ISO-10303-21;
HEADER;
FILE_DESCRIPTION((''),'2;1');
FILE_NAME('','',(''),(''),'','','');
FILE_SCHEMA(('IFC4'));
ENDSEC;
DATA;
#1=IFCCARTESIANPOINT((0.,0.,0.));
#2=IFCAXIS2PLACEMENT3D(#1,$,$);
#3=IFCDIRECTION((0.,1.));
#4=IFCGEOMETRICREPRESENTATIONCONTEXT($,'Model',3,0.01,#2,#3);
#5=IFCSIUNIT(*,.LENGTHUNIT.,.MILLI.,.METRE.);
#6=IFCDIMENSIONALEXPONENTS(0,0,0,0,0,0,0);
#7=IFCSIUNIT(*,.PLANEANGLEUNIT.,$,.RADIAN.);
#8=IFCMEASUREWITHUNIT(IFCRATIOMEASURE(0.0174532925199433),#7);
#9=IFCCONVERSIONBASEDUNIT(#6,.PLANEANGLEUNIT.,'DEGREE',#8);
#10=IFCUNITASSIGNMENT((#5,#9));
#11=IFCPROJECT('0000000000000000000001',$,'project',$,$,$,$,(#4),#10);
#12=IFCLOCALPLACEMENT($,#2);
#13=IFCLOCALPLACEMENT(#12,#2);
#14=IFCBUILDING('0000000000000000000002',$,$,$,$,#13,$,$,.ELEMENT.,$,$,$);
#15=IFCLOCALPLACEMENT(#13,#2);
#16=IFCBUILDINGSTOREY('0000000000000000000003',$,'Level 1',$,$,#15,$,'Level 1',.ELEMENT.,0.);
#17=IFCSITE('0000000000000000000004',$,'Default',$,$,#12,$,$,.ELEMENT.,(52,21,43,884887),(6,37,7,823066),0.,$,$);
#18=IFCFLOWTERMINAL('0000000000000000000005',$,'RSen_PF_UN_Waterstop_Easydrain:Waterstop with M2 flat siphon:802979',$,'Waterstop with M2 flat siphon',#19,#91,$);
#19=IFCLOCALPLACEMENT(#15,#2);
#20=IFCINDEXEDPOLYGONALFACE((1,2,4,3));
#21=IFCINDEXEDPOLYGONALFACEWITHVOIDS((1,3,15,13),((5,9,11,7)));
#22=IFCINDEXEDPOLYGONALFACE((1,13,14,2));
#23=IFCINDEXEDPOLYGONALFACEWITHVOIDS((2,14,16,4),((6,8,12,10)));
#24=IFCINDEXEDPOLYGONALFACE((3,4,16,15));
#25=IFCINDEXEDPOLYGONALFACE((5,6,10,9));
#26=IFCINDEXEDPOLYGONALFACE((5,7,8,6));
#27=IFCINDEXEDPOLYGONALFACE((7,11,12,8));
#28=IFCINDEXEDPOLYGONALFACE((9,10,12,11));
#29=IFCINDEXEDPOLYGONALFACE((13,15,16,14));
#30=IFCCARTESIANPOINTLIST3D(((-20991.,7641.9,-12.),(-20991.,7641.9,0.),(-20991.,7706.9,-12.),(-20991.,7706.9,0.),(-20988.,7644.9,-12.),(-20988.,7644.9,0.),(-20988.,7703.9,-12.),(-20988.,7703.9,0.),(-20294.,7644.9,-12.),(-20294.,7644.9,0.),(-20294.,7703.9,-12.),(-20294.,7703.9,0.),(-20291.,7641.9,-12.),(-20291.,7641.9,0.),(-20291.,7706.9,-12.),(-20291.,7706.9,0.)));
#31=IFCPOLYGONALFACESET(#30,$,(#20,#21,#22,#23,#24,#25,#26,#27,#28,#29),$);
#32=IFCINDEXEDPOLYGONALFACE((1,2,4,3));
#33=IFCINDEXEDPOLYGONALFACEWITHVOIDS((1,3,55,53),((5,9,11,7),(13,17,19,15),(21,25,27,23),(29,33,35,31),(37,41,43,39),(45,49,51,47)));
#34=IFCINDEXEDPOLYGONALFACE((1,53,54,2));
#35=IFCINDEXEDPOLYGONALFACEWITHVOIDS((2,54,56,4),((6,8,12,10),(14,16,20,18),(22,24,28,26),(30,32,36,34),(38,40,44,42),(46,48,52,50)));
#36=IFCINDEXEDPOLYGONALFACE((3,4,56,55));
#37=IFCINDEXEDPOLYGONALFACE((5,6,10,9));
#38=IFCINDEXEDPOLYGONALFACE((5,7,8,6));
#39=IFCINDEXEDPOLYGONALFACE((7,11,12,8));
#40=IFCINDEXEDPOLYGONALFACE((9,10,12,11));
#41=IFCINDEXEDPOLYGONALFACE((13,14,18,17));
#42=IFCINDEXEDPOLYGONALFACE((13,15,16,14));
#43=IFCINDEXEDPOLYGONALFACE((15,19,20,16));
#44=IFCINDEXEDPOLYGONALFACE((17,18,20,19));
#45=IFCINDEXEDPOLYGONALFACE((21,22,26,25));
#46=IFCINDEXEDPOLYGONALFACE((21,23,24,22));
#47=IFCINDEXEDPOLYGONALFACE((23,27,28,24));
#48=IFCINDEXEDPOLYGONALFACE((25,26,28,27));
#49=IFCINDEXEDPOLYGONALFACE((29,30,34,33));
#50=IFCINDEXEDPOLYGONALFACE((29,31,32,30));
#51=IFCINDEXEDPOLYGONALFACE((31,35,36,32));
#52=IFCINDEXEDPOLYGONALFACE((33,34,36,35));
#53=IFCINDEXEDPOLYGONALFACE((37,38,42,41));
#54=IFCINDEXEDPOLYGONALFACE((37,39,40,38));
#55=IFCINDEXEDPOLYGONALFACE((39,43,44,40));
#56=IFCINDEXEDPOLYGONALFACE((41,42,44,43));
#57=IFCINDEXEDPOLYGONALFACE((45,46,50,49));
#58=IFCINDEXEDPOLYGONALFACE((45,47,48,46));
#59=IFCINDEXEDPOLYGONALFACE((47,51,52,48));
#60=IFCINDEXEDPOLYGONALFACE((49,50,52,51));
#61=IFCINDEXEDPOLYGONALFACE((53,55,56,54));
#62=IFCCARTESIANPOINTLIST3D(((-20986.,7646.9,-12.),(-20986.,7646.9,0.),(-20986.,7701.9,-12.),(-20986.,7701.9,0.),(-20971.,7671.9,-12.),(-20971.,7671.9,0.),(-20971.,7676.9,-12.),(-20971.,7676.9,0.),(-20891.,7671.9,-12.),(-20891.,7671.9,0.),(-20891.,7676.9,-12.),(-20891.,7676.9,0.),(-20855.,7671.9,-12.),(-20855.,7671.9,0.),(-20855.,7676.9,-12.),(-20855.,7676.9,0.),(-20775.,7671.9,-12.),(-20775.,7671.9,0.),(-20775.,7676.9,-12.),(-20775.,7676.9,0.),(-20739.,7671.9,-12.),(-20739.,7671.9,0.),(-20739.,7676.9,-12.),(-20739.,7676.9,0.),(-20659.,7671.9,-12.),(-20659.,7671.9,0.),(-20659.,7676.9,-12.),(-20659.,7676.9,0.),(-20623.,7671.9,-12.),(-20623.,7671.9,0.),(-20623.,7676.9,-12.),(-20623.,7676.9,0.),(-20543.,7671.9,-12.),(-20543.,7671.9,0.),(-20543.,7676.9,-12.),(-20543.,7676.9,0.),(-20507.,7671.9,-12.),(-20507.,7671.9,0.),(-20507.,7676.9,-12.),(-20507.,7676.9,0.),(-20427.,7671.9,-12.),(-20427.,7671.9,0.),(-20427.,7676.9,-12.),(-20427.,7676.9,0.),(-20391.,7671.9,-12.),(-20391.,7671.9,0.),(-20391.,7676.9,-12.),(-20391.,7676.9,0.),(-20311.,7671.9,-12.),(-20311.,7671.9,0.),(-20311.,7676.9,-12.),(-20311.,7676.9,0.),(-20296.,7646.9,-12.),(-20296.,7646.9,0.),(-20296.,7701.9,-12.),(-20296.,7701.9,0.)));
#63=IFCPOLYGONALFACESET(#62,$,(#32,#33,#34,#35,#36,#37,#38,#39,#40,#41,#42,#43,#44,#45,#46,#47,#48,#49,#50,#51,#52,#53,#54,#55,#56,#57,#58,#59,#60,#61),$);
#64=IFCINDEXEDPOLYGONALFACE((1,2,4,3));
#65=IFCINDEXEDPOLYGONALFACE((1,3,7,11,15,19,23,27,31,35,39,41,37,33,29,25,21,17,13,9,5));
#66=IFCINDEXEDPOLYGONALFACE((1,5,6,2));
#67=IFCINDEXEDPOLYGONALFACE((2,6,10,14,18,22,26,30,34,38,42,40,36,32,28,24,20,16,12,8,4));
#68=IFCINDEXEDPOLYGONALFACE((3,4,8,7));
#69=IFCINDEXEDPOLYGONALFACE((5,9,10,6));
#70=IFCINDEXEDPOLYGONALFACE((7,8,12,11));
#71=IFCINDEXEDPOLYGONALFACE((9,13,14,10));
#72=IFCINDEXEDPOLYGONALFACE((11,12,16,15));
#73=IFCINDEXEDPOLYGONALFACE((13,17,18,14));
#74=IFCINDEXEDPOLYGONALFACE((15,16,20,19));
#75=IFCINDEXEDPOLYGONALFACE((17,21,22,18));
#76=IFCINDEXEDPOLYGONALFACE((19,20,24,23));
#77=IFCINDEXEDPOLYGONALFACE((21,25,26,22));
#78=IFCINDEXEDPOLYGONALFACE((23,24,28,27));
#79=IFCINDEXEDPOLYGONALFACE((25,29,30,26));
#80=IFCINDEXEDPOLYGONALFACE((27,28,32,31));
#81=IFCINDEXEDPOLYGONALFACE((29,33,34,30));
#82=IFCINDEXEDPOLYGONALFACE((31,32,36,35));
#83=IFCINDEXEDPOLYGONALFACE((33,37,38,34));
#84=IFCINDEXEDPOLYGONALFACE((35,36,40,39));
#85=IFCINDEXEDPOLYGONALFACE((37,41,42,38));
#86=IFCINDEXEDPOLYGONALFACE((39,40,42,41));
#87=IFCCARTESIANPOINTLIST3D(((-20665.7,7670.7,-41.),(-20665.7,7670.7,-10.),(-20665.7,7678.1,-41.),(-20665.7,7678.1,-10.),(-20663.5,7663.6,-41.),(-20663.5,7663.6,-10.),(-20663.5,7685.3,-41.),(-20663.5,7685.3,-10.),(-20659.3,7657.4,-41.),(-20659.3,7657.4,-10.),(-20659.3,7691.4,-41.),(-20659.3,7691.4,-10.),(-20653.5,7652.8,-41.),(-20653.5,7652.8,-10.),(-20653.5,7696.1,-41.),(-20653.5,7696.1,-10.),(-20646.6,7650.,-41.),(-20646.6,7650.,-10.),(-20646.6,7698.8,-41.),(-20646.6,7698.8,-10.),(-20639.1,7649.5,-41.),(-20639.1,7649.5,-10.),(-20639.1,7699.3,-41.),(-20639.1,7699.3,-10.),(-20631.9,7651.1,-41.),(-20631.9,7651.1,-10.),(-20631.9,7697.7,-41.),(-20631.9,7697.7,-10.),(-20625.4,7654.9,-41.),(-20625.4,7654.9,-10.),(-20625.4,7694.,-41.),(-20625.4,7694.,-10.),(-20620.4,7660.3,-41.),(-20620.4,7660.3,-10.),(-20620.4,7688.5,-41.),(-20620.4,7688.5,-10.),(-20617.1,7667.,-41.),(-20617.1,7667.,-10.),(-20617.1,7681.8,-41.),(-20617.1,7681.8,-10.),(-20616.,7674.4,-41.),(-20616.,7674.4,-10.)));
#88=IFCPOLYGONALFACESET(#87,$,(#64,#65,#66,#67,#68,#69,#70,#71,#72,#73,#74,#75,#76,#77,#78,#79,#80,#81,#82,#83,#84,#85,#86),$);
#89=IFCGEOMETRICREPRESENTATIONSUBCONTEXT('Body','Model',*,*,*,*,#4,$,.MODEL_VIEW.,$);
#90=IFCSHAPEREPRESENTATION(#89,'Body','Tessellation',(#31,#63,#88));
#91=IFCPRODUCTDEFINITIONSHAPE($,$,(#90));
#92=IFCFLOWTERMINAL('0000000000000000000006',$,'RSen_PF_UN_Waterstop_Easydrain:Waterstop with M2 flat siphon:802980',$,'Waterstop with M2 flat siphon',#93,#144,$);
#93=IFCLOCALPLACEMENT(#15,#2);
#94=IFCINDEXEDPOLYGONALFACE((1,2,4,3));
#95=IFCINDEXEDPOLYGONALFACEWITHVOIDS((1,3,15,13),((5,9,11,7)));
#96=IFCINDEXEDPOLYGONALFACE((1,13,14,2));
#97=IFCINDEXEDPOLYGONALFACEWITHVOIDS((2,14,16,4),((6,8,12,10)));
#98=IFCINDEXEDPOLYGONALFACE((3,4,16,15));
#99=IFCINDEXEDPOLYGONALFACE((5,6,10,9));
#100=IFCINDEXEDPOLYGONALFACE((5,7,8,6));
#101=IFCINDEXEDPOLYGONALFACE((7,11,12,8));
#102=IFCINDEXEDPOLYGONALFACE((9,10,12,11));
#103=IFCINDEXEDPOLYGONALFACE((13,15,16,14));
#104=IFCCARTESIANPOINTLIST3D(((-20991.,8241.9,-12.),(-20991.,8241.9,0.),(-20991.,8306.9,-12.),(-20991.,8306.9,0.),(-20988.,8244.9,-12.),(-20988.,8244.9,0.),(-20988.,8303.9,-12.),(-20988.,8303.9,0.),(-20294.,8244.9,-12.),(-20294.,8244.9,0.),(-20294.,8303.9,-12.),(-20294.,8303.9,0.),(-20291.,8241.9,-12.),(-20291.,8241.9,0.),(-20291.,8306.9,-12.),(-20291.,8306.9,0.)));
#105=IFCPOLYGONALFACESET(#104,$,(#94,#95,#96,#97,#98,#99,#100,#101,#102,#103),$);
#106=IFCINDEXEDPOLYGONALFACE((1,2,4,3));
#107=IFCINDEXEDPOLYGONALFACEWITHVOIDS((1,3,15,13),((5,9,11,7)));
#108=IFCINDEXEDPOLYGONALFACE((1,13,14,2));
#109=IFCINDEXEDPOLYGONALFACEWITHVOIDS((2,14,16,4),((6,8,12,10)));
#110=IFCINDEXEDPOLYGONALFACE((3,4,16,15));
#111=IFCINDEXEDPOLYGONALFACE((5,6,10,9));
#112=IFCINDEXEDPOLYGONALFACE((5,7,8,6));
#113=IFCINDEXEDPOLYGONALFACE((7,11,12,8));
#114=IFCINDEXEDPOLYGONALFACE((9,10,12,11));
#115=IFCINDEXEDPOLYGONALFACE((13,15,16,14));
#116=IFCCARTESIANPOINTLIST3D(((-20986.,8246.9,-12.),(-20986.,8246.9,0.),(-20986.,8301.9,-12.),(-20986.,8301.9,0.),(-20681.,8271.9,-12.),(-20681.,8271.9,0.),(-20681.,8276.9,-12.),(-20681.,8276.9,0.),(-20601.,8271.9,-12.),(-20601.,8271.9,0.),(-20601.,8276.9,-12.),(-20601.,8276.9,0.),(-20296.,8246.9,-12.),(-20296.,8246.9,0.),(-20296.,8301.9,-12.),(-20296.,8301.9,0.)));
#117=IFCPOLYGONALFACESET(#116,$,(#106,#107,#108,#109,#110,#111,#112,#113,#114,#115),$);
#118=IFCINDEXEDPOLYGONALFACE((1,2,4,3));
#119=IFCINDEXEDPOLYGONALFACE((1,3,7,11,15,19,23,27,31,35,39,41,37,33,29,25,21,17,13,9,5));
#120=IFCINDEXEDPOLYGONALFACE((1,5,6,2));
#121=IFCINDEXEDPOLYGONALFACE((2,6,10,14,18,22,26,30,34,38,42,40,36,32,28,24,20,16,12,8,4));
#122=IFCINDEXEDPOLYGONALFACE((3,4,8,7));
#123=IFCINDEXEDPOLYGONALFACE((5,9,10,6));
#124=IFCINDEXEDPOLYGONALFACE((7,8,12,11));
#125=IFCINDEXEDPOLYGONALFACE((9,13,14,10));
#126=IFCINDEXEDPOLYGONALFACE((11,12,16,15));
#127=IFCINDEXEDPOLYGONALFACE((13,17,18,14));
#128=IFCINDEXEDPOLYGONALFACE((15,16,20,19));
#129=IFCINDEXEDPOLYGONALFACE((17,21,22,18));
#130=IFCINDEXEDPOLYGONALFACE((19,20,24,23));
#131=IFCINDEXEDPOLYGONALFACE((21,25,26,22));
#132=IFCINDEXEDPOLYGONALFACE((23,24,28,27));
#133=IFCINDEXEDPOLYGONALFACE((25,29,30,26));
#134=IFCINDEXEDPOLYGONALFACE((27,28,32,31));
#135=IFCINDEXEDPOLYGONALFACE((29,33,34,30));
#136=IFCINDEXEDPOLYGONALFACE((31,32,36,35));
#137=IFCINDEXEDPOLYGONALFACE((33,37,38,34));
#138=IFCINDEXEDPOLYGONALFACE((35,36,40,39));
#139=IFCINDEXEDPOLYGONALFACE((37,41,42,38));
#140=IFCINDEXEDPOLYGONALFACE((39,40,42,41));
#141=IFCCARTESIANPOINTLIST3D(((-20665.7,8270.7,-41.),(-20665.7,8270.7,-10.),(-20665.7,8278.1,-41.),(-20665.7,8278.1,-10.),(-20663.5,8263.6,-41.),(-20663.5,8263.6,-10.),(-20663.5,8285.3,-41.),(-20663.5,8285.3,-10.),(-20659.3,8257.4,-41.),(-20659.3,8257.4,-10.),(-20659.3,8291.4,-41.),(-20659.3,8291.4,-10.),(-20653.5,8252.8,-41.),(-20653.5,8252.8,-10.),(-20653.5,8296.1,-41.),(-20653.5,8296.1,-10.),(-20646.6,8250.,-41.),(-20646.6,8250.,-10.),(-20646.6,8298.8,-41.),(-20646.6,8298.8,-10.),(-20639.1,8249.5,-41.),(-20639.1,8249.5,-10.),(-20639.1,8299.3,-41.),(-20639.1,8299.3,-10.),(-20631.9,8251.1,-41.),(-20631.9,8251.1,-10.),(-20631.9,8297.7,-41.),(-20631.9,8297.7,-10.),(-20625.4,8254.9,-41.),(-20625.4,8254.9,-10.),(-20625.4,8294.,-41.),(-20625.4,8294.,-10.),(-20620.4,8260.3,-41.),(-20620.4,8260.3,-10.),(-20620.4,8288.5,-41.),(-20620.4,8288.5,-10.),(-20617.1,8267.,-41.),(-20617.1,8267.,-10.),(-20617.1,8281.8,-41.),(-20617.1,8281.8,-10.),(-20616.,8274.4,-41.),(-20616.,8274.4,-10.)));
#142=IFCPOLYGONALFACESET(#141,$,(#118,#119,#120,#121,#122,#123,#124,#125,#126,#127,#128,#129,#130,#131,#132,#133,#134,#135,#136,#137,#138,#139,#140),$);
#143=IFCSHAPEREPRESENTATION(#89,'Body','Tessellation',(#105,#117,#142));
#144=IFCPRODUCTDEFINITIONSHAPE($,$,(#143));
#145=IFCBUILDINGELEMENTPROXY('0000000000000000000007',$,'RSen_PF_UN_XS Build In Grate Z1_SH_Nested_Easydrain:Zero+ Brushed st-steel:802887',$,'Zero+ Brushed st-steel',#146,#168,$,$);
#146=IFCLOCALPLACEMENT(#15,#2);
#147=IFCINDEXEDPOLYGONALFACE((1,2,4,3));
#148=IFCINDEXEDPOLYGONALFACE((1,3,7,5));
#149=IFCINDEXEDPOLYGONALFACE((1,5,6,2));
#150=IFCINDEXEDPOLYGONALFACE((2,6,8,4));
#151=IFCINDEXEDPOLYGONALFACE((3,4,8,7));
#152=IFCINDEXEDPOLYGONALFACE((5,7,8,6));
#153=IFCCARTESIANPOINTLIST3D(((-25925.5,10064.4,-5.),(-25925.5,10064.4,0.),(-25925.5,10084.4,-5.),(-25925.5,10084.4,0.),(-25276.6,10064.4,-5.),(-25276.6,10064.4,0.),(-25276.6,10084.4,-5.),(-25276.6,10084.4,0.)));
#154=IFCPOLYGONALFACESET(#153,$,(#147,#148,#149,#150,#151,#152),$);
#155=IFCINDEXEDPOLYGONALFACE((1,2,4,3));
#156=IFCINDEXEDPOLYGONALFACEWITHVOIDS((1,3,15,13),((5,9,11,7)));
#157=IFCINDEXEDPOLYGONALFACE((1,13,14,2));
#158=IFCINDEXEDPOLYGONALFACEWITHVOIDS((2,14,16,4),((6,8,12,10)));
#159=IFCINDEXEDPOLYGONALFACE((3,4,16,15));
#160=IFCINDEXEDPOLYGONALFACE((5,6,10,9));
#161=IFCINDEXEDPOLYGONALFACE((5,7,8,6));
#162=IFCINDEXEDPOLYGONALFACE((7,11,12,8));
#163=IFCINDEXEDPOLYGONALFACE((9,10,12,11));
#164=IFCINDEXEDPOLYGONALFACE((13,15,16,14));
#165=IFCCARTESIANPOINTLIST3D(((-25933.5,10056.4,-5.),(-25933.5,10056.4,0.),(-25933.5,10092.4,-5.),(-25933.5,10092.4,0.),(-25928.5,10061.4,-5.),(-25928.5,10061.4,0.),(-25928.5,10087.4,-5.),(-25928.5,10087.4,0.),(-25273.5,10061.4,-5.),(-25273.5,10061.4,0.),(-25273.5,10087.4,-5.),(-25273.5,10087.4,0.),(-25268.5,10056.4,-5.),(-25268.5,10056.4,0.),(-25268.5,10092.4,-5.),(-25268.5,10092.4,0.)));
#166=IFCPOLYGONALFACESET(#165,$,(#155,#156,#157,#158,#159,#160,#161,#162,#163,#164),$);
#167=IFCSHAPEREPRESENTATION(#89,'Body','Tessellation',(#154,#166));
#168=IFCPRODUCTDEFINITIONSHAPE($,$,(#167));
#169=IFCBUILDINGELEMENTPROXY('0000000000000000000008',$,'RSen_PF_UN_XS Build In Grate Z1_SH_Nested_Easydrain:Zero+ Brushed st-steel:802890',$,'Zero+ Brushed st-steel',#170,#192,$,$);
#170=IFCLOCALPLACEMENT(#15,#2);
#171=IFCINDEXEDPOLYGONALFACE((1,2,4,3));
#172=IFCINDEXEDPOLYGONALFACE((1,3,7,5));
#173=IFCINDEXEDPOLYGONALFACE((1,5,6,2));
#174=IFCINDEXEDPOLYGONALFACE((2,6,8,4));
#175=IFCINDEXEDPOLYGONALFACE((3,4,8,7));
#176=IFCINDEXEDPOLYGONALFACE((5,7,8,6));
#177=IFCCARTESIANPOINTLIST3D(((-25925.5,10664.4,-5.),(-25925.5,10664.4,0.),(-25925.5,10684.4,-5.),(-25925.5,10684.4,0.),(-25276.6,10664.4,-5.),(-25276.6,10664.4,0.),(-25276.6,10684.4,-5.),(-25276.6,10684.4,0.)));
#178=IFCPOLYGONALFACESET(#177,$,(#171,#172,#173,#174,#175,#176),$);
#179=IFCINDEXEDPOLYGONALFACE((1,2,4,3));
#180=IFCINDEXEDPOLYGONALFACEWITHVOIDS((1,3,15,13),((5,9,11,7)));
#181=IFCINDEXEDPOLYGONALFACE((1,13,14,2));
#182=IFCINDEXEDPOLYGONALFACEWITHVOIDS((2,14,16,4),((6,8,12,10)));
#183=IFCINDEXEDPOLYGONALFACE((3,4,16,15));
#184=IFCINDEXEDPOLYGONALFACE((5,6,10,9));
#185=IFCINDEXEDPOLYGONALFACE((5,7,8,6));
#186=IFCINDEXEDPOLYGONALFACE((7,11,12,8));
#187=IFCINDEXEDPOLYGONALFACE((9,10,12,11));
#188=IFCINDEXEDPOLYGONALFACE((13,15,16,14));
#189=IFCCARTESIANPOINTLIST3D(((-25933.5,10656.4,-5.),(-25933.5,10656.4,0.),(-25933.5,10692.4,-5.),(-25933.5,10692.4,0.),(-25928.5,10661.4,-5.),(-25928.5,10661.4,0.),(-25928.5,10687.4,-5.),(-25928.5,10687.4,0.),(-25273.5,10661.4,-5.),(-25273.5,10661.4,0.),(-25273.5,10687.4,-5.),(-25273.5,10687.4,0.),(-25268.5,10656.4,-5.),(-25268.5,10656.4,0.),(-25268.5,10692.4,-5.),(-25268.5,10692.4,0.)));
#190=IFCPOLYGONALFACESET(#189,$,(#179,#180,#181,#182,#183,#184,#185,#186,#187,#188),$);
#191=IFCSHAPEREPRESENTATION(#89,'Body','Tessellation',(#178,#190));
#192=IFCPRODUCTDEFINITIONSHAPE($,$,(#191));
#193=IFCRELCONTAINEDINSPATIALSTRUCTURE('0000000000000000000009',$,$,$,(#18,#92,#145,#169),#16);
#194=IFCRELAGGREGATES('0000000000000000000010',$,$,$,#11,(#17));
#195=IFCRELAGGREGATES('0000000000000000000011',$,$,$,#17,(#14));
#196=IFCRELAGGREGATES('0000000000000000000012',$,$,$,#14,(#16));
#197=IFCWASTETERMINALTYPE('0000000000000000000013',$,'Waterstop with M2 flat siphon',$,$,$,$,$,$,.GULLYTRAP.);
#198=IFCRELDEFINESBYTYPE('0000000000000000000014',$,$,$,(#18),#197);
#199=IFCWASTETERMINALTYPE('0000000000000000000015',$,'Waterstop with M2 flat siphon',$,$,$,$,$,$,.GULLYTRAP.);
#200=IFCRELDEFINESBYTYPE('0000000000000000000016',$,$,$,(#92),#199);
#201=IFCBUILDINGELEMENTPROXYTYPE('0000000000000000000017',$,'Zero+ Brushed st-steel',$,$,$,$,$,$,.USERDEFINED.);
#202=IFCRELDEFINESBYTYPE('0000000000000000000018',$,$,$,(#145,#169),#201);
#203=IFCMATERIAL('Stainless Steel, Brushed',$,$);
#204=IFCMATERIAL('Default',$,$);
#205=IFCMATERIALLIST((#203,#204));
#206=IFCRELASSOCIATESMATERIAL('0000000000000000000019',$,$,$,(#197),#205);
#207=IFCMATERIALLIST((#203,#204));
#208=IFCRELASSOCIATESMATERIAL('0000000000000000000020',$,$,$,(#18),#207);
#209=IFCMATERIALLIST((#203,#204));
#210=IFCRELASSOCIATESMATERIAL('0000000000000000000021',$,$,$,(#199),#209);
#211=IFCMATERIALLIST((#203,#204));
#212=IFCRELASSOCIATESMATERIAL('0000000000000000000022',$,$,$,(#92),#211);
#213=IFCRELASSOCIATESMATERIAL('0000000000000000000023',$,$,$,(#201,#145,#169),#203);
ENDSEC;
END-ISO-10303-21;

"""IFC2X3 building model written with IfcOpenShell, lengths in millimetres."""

from ifc_helpers import new_model, entity, si_unit, converted_unit, direction, frame, frame_2d, origin, origin_2d_with_axis, place, context, subcontext, project, spatial, polyline, rectangle, circle, outline, extrude, source, transform, mapped, material, material_list, type_object, type_shapes, element, save


model = new_model("IFC2X3")

# Units and contexts
model_context = context("Model", 3, precision=0.01, world=origin(), true_north=direction((0.0, 1.0)))
body_context = subcontext(model_context, "Body", "Model", "MODEL_VIEW")
ifc_project = project(units=[si_unit("LENGTHUNIT", "METRE", prefix="MILLI"), converted_unit("PLANEANGLEUNIT", "DEGREE", entity("IfcRatioMeasure", 0.0174532925199433), si_unit("PLANEANGLEUNIT", "RADIAN"), dimensions=[0, 0, 0, 0, 0, 0, 0])], contexts=[model_context])

# Site, building, storey
site_placement = place(None, origin())
site = spatial("IfcSite", under=ifc_project, at=site_placement, Name="Default", CompositionType="ELEMENT", RefLatitude=(52, 21, 43, 884887), RefLongitude=(6, 37, 7, 823066), RefElevation=0.0)
building_placement = place(site_placement, origin())
building = spatial("IfcBuilding", under=site, at=building_placement, CompositionType="ELEMENT")
storey_placement = place(building_placement, origin())
storey = spatial("IfcBuildingStorey", under=building, at=storey_placement, Name="Level 1", LongName="Level 1", CompositionType="ELEMENT", Elevation=0.0)

# Flow terminals
ifc_material_1 = material(Name="Stainless Steel, Brushed")
ifc_material_2 = material(Name="Default")
ifc_material_list_1 = material_list([ifc_material_1, ifc_material_2])
ifc_material_list_2 = material_list([ifc_material_1, ifc_material_2])
waste_terminal_type_1 = type_object("IfcWasteTerminalType", Name="Waterstop with M2 flat siphon", PredefinedType="GULLYTRAP", material=ifc_material_list_2)
shared_shape_1 = source(origin(), body_context, "Body", "SweptSolid", [
    extrude(outline(polyline([(-350.0, -32.5), (350.0, -32.5), (350.0, 32.5), (-350.0, 32.5), (-350.0, -32.5)]), holes=[polyline([(-347.0, -29.5), (-347.0, 29.5), (347.0, 29.5), (347.0, -29.5), (-347.0, -29.5)])]), frame((0.0, 0.0, -12.0), z_axis=(0.0, 0.0, 1.0), x_axis=(-1.0, 0.0, 0.0)), (0.0, 0.0, 1.0), 12.0),
    extrude(outline(polyline([(-345.0, -27.5), (345.0, -27.5), (345.0, 27.5), (-345.0, 27.5), (-345.0, -27.5)]), holes=[polyline([(250.0, -2.5), (250.0, 2.5), (330.0, 2.5), (330.0, -2.5), (250.0, -2.5)]), polyline([(-330.0, -2.5), (-330.0, 2.5), (-250.0, 2.5), (-250.0, -2.5), (-330.0, -2.5)]), polyline([(134.0, -2.5), (134.0, 2.5), (214.0, 2.5), (214.0, -2.5), (134.0, -2.5)]), polyline([(18.0, -2.5), (18.0, 2.5), (98.0, 2.5), (98.0, -2.5), (18.0, -2.5)]), polyline([(-98.0, -2.5), (-98.0, 2.5), (-18.0, 2.5), (-18.0, -2.5), (-98.0, -2.5)]), polyline([(-214.0, -2.5), (-214.0, 2.5), (-134.0, 2.5), (-134.0, -2.5), (-214.0, -2.5)])]), frame((0.0, 0.0, -12.0), z_axis=(0.0, 0.0, 1.0), x_axis=(-1.0, 0.0, 0.0)), (0.0, 0.0, 1.0), 12.0),
    extrude(circle(Radius=25.0, at=frame_2d((0.0, 0.0), x_axis=(1.0, 0.0))), frame((0.0, 0.0, -41.0)), (0.0, 0.0, 1.0), 31.0),
])
type_shapes(waste_terminal_type_1, [shared_shape_1])
flow_terminal_1_placement = place(storey_placement, frame((-20641.0, 7674.4, 0.0)))
element("IfcFlowTerminal", 1, at=flow_terminal_1_placement, inside=storey, type_object=waste_terminal_type_1, material=ifc_material_list_1, Name="RSen_PF_UN_Waterstop_Easydrain:Waterstop with M2 flat siphon:802979", ObjectType="Waterstop with M2 flat siphon", context=body_context, shape_type="MappedRepresentation", body=[
    mapped(shared_shape_1, transform((0.0, 0.0, 0.0), scale=1.0)),
])
ifc_material_list_3 = material_list([ifc_material_1, ifc_material_2])
ifc_material_list_4 = material_list([ifc_material_1, ifc_material_2])
waste_terminal_type_2 = type_object("IfcWasteTerminalType", Name="Waterstop with M2 flat siphon", PredefinedType="GULLYTRAP", material=ifc_material_list_4)
shared_shape_2 = source(origin(), body_context, "Body", "SweptSolid", [
    extrude(outline(polyline([(-350.0, -32.5), (350.0, -32.5), (350.0, 32.5), (-350.0, 32.5), (-350.0, -32.5)]), holes=[polyline([(-347.0, -29.5), (-347.0, 29.5), (347.0, 29.5), (347.0, -29.5), (-347.0, -29.5)])]), frame((0.0, 0.0, -12.0), z_axis=(0.0, 0.0, 1.0), x_axis=(-1.0, 0.0, 0.0)), (0.0, 0.0, 1.0), 12.0),
    extrude(outline(polyline([(-345.0, -27.5), (345.0, -27.5), (345.0, 27.5), (-345.0, 27.5), (-345.0, -27.5)]), holes=[polyline([(-40.0, -2.5), (-40.0, 2.5), (40.0, 2.5), (40.0, -2.5), (-40.0, -2.5)])]), frame((0.0, 0.0, -12.0), z_axis=(0.0, 0.0, 1.0), x_axis=(-1.0, 0.0, 0.0)), (0.0, 0.0, 1.0), 12.0),
    extrude(circle(Radius=25.0, at=frame_2d((0.0, 0.0), x_axis=(1.0, 0.0))), frame((0.0, 0.0, -41.0)), (0.0, 0.0, 1.0), 31.0),
])
type_shapes(waste_terminal_type_2, [shared_shape_2])
flow_terminal_2_placement = place(storey_placement, frame((-20641.0, 8274.4, 0.0)))
element("IfcFlowTerminal", 2, at=flow_terminal_2_placement, inside=storey, type_object=waste_terminal_type_2, material=ifc_material_list_3, Name="RSen_PF_UN_Waterstop_Easydrain:Waterstop with M2 flat siphon:802980", ObjectType="Waterstop with M2 flat siphon", context=body_context, shape_type="MappedRepresentation", body=[
    mapped(shared_shape_2, transform((0.0, 0.0, 0.0), scale=1.0)),
])

# Building element proxies
building_element_proxy_type_1 = type_object("IfcBuildingElementProxyType", Name="Zero+ Brushed st-steel", PredefinedType="USERDEFINED", material=ifc_material_1)
shared_shape_3 = source(origin(), body_context, "Body", "SweptSolid", [
    extrude(rectangle(XDim=649.0, YDim=20.0, at=origin_2d_with_axis()), frame((0.0, 0.0, 0.0), z_axis=(0.0, 0.0, 1.0), x_axis=(-1.0, 0.0, 0.0)), (0.0, 0.0, 1.0), 5.0),
    extrude(outline(polyline([(-332.5, -18.0), (332.5, -18.0), (332.5, 18.0), (-332.5, 18.0), (-332.5, -18.0)]), holes=[polyline([(-327.5, -13.0), (-327.5, 13.0), (327.5, 13.0), (327.5, -13.0), (-327.5, -13.0)])]), frame((0.0, 0.0, 0.0), z_axis=(0.0, 0.0, 1.0), x_axis=(-1.0, 0.0, 0.0)), (0.0, 0.0, 1.0), 5.0),
])
type_shapes(building_element_proxy_type_1, [shared_shape_3])
for number, where, name in (
    (3, (-25601.0, 10074.4, -5.0), "RSen_PF_UN_XS Build In Grate Z1_SH_Nested_Easydrain:Zero+ Brushed st-steel:802887"),
    (4, (-25601.0, 10674.4, -5.0), "RSen_PF_UN_XS Build In Grate Z1_SH_Nested_Easydrain:Zero+ Brushed st-steel:802890"),
):
    element("IfcBuildingElementProxy", number, at=place(storey_placement, frame(where)), inside=storey, type_object=building_element_proxy_type_1, material=ifc_material_1, Name=name, ObjectType="Zero+ Brushed st-steel", context=body_context, shape_type="MappedRepresentation", body=[
        mapped(shared_shape_3, transform((0.0, 0.0, 0.0), scale=1.0)),
    ])

save(model, "model.ifc")
